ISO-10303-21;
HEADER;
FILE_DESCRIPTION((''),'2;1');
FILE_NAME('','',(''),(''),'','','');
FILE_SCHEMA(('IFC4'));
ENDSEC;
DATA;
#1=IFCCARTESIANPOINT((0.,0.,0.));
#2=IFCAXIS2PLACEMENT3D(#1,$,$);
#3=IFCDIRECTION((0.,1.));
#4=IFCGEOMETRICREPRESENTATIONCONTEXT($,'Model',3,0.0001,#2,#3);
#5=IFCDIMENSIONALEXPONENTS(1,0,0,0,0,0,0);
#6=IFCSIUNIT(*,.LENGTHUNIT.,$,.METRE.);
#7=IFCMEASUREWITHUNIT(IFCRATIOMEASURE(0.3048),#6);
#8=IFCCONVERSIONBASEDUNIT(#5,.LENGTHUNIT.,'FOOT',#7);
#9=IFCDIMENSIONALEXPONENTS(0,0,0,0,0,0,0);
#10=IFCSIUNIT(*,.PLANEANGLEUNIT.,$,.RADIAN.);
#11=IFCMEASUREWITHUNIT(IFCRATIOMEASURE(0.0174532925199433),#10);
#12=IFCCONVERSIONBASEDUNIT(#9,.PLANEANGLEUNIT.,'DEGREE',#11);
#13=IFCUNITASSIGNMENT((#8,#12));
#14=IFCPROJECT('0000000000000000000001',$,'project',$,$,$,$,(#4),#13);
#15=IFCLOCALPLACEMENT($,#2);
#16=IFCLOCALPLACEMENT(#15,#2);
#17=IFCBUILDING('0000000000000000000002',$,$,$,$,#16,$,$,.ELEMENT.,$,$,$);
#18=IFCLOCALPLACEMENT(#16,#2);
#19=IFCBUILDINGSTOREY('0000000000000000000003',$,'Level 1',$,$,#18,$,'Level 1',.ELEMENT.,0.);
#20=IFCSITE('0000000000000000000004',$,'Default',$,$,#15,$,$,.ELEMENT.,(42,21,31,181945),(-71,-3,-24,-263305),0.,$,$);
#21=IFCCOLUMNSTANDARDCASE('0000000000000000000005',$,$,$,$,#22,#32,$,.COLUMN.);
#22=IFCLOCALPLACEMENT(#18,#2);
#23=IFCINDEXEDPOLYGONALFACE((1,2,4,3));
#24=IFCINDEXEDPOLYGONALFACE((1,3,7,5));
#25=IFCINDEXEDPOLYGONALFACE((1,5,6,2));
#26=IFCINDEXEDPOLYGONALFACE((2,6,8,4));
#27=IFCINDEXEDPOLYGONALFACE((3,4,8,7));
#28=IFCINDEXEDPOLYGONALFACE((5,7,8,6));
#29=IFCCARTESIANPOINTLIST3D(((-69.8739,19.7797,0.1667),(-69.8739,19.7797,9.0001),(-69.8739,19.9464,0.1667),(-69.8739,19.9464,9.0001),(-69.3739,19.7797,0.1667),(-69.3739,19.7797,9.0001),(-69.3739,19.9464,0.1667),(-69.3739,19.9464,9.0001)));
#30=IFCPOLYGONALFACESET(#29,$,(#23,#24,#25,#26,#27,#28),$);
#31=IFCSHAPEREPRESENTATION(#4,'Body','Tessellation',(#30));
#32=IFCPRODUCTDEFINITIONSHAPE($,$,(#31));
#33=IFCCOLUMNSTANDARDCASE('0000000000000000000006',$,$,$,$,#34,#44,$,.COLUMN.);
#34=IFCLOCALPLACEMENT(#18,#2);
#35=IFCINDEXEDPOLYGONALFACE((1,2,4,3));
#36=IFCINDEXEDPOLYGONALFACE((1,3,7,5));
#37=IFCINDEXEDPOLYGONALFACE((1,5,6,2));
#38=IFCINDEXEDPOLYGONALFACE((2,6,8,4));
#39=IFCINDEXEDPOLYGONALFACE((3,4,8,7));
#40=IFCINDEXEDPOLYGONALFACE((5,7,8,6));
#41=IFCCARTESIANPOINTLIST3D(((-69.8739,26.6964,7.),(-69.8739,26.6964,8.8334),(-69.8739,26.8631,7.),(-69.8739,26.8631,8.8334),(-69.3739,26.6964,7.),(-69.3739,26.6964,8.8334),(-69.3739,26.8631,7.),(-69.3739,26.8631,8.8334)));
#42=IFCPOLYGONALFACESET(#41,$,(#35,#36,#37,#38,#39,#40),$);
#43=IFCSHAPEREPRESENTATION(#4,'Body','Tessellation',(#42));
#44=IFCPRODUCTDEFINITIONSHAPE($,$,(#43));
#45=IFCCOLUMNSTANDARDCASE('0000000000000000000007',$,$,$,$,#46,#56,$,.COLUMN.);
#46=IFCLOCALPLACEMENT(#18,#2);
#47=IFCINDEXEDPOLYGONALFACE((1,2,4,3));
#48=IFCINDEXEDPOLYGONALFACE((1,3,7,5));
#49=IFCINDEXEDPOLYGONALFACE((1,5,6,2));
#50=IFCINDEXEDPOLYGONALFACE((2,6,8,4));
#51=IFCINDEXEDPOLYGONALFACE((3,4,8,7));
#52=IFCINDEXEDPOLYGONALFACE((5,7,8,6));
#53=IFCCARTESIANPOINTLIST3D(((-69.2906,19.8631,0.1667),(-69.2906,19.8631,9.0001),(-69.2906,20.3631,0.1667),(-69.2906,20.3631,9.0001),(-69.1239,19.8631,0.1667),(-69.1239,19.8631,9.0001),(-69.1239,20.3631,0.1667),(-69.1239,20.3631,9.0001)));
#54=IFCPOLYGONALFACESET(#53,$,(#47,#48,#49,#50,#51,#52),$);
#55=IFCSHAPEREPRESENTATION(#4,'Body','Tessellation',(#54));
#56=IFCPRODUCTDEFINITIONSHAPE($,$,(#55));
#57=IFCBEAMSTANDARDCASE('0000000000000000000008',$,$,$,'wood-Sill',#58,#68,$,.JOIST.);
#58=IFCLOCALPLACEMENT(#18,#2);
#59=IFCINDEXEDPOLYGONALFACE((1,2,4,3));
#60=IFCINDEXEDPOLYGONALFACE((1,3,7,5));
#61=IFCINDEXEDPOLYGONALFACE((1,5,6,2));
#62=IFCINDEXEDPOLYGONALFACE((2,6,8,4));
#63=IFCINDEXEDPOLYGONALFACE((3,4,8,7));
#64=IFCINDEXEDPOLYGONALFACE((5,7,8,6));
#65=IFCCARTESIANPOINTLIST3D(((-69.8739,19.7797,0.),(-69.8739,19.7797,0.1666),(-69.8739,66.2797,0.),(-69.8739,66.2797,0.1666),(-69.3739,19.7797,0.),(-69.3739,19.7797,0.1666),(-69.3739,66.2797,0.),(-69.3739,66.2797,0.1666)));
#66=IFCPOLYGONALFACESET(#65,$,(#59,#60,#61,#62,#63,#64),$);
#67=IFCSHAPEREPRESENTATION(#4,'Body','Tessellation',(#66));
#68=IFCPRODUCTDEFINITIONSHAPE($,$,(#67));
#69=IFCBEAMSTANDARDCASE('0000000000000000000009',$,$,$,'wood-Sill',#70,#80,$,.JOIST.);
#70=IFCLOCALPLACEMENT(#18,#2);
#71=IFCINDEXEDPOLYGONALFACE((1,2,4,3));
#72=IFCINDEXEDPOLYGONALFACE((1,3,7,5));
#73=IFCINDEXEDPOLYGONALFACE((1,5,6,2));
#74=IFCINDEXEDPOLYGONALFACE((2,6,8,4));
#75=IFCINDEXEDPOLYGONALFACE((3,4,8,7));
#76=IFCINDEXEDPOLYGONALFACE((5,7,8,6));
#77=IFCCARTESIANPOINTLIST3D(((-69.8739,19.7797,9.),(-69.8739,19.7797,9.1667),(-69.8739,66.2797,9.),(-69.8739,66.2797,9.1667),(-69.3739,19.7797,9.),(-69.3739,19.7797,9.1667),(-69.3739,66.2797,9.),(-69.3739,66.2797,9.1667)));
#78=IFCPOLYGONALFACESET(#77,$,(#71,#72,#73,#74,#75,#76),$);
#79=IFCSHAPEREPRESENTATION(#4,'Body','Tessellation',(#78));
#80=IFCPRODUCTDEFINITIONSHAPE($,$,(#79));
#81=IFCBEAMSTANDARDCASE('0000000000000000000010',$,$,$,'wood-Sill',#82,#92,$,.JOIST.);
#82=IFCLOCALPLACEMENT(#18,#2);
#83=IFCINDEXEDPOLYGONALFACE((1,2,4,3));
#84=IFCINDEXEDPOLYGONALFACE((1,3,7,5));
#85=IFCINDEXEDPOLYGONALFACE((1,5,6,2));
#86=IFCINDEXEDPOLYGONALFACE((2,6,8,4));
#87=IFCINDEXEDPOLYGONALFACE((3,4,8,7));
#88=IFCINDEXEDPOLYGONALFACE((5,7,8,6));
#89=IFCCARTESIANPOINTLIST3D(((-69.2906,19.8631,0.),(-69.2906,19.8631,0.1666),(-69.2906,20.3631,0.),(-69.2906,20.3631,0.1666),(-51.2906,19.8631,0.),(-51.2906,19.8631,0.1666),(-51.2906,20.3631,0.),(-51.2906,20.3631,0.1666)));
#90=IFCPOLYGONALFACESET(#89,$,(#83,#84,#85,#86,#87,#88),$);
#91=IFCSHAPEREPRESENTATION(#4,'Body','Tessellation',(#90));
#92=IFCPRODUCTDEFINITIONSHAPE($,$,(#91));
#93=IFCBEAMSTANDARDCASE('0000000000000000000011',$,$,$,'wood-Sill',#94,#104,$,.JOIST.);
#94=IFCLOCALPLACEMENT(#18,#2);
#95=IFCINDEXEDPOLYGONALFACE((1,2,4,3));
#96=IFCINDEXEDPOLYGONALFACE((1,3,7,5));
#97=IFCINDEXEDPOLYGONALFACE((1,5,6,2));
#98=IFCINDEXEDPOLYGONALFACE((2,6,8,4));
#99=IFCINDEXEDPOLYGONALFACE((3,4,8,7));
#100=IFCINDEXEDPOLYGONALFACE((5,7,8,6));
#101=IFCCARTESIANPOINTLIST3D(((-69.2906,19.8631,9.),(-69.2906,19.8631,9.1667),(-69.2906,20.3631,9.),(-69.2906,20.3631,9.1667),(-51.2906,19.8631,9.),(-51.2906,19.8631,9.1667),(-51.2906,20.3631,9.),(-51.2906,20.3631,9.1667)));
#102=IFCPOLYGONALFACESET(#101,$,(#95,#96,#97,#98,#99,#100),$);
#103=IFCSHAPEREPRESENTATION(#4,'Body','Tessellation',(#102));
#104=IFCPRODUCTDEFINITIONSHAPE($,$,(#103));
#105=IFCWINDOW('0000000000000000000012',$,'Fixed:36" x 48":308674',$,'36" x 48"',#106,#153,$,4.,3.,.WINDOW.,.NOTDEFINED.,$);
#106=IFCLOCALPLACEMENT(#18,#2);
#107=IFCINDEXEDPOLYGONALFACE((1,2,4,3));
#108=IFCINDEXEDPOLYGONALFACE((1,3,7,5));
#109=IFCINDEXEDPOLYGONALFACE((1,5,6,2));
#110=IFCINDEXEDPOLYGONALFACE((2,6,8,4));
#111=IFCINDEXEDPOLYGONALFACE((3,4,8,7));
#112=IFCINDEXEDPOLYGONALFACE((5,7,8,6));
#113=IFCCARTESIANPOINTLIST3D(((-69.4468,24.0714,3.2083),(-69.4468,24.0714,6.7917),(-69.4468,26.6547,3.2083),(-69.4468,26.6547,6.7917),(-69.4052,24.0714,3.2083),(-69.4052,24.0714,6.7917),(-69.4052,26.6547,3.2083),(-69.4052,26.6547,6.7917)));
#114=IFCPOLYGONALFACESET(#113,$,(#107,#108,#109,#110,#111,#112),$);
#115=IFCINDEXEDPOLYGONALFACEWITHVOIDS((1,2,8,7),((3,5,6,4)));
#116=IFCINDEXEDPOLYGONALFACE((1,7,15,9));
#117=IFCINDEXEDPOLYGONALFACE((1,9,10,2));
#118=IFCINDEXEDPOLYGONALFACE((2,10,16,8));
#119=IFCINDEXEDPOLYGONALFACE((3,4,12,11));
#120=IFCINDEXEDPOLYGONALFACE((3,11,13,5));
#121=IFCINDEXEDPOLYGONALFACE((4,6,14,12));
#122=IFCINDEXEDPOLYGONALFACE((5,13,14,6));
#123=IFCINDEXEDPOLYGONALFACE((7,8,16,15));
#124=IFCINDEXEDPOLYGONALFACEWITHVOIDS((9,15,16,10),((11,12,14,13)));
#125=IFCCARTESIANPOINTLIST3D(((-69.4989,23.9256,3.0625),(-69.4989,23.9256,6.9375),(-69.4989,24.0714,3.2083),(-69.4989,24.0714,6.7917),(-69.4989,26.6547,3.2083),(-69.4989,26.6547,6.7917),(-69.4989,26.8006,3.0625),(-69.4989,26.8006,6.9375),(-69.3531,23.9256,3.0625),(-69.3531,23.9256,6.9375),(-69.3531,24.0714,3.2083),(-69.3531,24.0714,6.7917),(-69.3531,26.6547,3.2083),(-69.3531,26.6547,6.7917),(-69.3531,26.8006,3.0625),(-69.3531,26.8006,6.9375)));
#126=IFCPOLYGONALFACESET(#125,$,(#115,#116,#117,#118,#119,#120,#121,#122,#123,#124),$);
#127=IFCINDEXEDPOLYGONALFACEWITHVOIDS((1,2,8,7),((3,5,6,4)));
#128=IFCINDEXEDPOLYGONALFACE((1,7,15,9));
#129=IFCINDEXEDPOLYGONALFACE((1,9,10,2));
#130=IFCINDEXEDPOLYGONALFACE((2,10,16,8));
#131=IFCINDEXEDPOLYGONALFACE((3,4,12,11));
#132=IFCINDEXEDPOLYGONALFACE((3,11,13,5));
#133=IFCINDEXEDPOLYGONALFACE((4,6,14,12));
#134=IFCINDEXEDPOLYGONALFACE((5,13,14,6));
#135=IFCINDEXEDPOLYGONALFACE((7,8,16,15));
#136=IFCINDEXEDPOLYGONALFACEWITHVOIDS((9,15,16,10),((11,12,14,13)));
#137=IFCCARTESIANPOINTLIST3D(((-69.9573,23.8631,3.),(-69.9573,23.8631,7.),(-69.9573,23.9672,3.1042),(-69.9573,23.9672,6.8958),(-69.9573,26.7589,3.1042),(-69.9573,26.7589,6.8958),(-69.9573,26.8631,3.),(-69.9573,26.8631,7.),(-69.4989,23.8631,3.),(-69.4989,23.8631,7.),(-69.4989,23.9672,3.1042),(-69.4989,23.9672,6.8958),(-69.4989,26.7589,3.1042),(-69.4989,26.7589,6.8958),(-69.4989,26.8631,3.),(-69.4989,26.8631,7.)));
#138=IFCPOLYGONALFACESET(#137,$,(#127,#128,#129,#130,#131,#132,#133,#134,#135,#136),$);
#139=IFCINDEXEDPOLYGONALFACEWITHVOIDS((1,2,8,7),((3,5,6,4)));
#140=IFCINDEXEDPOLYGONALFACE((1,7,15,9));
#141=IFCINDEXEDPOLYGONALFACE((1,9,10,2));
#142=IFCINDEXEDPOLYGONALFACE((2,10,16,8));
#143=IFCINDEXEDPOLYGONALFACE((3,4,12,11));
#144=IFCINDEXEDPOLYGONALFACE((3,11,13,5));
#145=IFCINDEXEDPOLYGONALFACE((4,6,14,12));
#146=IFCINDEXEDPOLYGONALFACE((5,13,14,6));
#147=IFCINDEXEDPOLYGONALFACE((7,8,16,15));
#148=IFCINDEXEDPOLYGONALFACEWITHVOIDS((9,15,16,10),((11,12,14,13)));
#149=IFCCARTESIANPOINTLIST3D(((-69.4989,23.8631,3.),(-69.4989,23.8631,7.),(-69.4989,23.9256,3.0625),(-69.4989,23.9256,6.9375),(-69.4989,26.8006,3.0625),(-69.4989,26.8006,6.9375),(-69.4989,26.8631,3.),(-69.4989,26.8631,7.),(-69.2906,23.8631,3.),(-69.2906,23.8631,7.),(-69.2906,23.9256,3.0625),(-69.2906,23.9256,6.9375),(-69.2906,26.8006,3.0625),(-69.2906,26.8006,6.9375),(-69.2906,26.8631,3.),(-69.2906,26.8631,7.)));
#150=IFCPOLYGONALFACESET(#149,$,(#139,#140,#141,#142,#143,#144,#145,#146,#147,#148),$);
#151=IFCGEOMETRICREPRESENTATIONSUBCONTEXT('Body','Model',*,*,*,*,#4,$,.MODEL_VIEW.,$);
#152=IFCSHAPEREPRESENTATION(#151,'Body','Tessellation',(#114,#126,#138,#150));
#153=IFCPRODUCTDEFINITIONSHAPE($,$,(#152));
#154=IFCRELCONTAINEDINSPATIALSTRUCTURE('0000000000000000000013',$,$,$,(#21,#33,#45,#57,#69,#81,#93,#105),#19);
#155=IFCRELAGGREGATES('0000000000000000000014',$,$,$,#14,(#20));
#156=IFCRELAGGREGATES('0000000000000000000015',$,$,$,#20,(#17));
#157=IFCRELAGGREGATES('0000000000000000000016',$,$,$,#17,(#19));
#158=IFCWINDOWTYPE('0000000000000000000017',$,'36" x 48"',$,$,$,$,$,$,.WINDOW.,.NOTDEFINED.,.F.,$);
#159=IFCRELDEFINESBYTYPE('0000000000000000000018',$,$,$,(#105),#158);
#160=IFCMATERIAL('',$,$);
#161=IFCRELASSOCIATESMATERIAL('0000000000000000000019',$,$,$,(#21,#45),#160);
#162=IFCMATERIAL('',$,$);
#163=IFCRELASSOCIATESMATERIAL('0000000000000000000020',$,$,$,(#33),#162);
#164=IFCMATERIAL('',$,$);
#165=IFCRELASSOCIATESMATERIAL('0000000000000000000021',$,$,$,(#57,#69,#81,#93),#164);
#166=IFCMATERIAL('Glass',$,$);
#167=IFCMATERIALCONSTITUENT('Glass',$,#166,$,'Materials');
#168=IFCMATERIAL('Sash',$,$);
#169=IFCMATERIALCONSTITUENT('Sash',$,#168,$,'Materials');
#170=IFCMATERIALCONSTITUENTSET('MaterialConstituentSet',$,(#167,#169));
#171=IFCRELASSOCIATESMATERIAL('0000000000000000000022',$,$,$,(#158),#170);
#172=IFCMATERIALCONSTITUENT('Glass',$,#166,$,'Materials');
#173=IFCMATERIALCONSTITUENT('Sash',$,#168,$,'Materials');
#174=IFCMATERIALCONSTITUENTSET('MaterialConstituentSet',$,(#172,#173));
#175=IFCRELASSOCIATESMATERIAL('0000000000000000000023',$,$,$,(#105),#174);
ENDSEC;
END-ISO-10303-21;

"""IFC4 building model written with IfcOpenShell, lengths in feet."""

from ifc_helpers import new_model, entity, si_unit, converted_unit, direction, frame, frame_2d, origin, origin_with_axes, place, context, subcontext, project, spatial, polyline, rectangle, outline, extrude, source, transform, mapped, material, constituent, constituent_set, type_object, type_shapes, element, save


model = new_model("IFC4")

# Units and contexts
model_context = context("Model", 3, precision=0.0001, world=origin(), true_north=direction((0.0, 1.0)))
body_context = subcontext(model_context, "Body", "Model", "MODEL_VIEW")
ifc_project = project(units=[converted_unit("LENGTHUNIT", "FOOT", entity("IfcRatioMeasure", 0.3048), si_unit("LENGTHUNIT", "METRE"), dimensions=[1, 0, 0, 0, 0, 0, 0]), converted_unit("PLANEANGLEUNIT", "DEGREE", entity("IfcRatioMeasure", 0.0174532925199433), si_unit("PLANEANGLEUNIT", "RADIAN"), dimensions=[0, 0, 0, 0, 0, 0, 0])], contexts=[model_context])

# Site, building, storey
site_placement = place(None, origin())
site = spatial("IfcSite", under=ifc_project, at=site_placement, Name="Default", CompositionType="ELEMENT", RefLatitude=(42, 21, 31, 181945), RefLongitude=(-71, -3, -24, -263305), RefElevation=0.0)
building_placement = place(site_placement, origin())
building = spatial("IfcBuilding", under=site, at=building_placement, CompositionType="ELEMENT")
storey_placement = place(building_placement, origin())
storey = spatial("IfcBuildingStorey", under=building, at=storey_placement, Name="Level 1", LongName="Level 1", CompositionType="ELEMENT", Elevation=0.0)

# Columns
ifc_material_1 = material(Name="")
placement_1 = place(storey_placement, frame((-69.6239, 19.7797, 0.0), z_axis=(0.0, 0.0, 1.0), x_axis=(0.0, 1.0, 0.0)))
for number, where, z_axis, x_axis in (
    (1, (0.0833, 0.0, 0.1667), (0.0, 0.0, 1.0), (1.0, 0.0, 0.0)),
):
    element("IfcColumnStandardCase", number, at=place(placement_1, frame(where, z_axis=z_axis, x_axis=x_axis)), inside=storey, material=ifc_material_1, PredefinedType="COLUMN", context=model_context, shape_type="SweptSolid", body=[
        extrude(rectangle(XDim=0.1667, YDim=0.5), origin(), (0.0, 0.0, 1.0), 8.8334),
    ])
ifc_material_2 = material(Name="")
for number, where, z_axis, x_axis in (
    (2, (7.0, 0.0, 7.0), (0.0, 0.0, 1.0), (1.0, 0.0, 0.0)),
):
    element("IfcColumnStandardCase", number, at=place(placement_1, frame(where, z_axis=z_axis, x_axis=x_axis)), inside=storey, material=ifc_material_2, PredefinedType="COLUMN", context=model_context, shape_type="SweptSolid", body=[
        extrude(rectangle(XDim=0.1667, YDim=0.5), origin(), (0.0, 0.0, 1.0), 1.8334),
    ])
placement_2 = place(storey_placement, frame((-69.2906, 20.1131, 0.0)))
for number, where, z_axis, x_axis in (
    (3, (0.0833, 0.0, 0.1667), (0.0, 0.0, 1.0), (1.0, 0.0, 0.0)),
):
    element("IfcColumnStandardCase", number, at=place(placement_2, frame(where, z_axis=z_axis, x_axis=x_axis)), inside=storey, material=ifc_material_1, PredefinedType="COLUMN", context=model_context, shape_type="SweptSolid", body=[
        extrude(rectangle(XDim=0.1667, YDim=0.5), origin(), (0.0, 0.0, 1.0), 8.8334),
    ])

# Beams
ifc_material_3 = material(Name="")
for number, where, z_axis, x_axis in (
    (4, (0.0, 0.0, 0.0833), (1.0, 0.0, 0.0), (0.0, 0.0, 1.0)),
    (5, (0.0, 0.0, 9.0834), (1.0, 0.0, 0.0), (0.0, 0.0, 1.0)),
):
    element("IfcBeamStandardCase", number, at=place(placement_1, frame(where, z_axis=z_axis, x_axis=x_axis)), inside=storey, material=ifc_material_3, ObjectType="wood-Sill", PredefinedType="JOIST", context=model_context, shape_type="SweptSolid", body=[
        extrude(rectangle(XDim=0.1667, YDim=0.5), origin_with_axes(), (0.0, 0.0, 1.0), 46.5),
    ])
for number, where, z_axis, x_axis in (
    (6, (0.0, 0.0, 0.0833), (1.0, 0.0, 0.0), (0.0, 0.0, 1.0)),
    (7, (0.0, 0.0, 9.0834), (1.0, 0.0, 0.0), (0.0, 0.0, 1.0)),
):
    element("IfcBeamStandardCase", number, at=place(placement_2, frame(where, z_axis=z_axis, x_axis=x_axis)), inside=storey, material=ifc_material_3, ObjectType="wood-Sill", PredefinedType="JOIST", context=model_context, shape_type="SweptSolid", body=[
        extrude(rectangle(XDim=0.1667, YDim=0.5), origin_with_axes(), (0.0, 0.0, 1.0), 18.0),
    ])

# Window
ifc_material_4 = material(Name="Glass")
ifc_constituent_1 = constituent(ifc_material_4, Name="Glass", Category="Materials")
ifc_material_5 = material(Name="Sash")
ifc_constituent_2 = constituent(ifc_material_5, Name="Sash", Category="Materials")
ifc_constituent_set_1 = constituent_set(constituents=[ifc_constituent_1, ifc_constituent_2], Name="MaterialConstituentSet")
ifc_constituent_3 = constituent(ifc_material_4, Name="Glass", Category="Materials")
ifc_constituent_4 = constituent(ifc_material_5, Name="Sash", Category="Materials")
ifc_constituent_set_2 = constituent_set(constituents=[ifc_constituent_3, ifc_constituent_4], Name="MaterialConstituentSet")
window_type = type_object("IfcWindowType", Name="36\" x 48\"", ParameterTakesPrecedence=False, PartitioningType="NOTDEFINED", PredefinedType="WINDOW", material=ifc_constituent_set_2)
shared_shape = source(origin(), body_context, "Body", "SweptSolid", [
    extrude(rectangle(XDim=2.5833, YDim=0.0417, at=frame_2d((0.0, 0.0), x_axis=(1.0, 0.0))), frame((1.75, 0.5312, 0.2083)), (0.0, 0.0, 1.0), 3.5833),
    extrude(outline(polyline([(-1.4375, -1.9375), (1.4375, -1.9375), (1.4375, 1.9375), (-1.4375, 1.9375), (-1.4375, -1.9375)]), holes=[polyline([(-1.2917, -1.7917), (-1.2917, 1.7917), (1.2917, 1.7917), (1.2917, -1.7917), (-1.2917, -1.7917)])]), frame((1.75, 0.6042, 2.0), z_axis=(0.0, -1.0, 0.0), x_axis=(-1.0, 0.0, 0.0)), (0.0, 0.0, 1.0), 0.1458),
    extrude(outline(polyline([(-1.5, -2.0), (1.5, -2.0), (1.5, 2.0), (-1.5, 2.0), (-1.5, -2.0)]), holes=[polyline([(-1.3958, -1.8958), (-1.3958, 1.8958), (1.3958, 1.8958), (1.3958, -1.8958), (-1.3958, -1.8958)])]), frame((1.75, 0.4583, 2.0), z_axis=(0.0, -1.0, 0.0), x_axis=(-1.0, 0.0, 0.0)), (0.0, 0.0, 1.0), 0.4583),
    extrude(outline(polyline([(-2.0, -1.5), (2.0, -1.5), (2.0, 1.5), (-2.0, 1.5), (-2.0, -1.5)]), holes=[polyline([(-1.9375, -1.4375), (-1.9375, 1.4375), (1.9375, 1.4375), (1.9375, -1.4375), (-1.9375, -1.4375)])]), frame((1.75, 0.6667, 2.0), z_axis=(0.0, -1.0, 0.0), x_axis=(0.0, 0.0, -1.0)), (0.0, 0.0, 1.0), 0.2083),
])
type_shapes(window_type, [shared_shape])
placement_3 = place(placement_1, frame((7.0833, 0.3333, 3.0)))
window_placement = place(placement_3, frame((0.25, 0.0, 0.0), z_axis=(0.0, 0.0, 1.0), x_axis=(-1.0, 0.0, 0.0)))
element("IfcWindow", 8, at=window_placement, inside=storey, type_object=window_type, material=ifc_constituent_set_1, Name="Fixed:36\" x 48\":308674", ObjectType="36\" x 48\"", OverallHeight=4.0, OverallWidth=3.0, PartitioningType="NOTDEFINED", PredefinedType="WINDOW", context=body_context, shape_type="MappedRepresentation", body=[
    mapped(shared_shape, transform((0.0, 0.0, 0.0), scale=1.0)),
])

save(model, "model.ifc")
